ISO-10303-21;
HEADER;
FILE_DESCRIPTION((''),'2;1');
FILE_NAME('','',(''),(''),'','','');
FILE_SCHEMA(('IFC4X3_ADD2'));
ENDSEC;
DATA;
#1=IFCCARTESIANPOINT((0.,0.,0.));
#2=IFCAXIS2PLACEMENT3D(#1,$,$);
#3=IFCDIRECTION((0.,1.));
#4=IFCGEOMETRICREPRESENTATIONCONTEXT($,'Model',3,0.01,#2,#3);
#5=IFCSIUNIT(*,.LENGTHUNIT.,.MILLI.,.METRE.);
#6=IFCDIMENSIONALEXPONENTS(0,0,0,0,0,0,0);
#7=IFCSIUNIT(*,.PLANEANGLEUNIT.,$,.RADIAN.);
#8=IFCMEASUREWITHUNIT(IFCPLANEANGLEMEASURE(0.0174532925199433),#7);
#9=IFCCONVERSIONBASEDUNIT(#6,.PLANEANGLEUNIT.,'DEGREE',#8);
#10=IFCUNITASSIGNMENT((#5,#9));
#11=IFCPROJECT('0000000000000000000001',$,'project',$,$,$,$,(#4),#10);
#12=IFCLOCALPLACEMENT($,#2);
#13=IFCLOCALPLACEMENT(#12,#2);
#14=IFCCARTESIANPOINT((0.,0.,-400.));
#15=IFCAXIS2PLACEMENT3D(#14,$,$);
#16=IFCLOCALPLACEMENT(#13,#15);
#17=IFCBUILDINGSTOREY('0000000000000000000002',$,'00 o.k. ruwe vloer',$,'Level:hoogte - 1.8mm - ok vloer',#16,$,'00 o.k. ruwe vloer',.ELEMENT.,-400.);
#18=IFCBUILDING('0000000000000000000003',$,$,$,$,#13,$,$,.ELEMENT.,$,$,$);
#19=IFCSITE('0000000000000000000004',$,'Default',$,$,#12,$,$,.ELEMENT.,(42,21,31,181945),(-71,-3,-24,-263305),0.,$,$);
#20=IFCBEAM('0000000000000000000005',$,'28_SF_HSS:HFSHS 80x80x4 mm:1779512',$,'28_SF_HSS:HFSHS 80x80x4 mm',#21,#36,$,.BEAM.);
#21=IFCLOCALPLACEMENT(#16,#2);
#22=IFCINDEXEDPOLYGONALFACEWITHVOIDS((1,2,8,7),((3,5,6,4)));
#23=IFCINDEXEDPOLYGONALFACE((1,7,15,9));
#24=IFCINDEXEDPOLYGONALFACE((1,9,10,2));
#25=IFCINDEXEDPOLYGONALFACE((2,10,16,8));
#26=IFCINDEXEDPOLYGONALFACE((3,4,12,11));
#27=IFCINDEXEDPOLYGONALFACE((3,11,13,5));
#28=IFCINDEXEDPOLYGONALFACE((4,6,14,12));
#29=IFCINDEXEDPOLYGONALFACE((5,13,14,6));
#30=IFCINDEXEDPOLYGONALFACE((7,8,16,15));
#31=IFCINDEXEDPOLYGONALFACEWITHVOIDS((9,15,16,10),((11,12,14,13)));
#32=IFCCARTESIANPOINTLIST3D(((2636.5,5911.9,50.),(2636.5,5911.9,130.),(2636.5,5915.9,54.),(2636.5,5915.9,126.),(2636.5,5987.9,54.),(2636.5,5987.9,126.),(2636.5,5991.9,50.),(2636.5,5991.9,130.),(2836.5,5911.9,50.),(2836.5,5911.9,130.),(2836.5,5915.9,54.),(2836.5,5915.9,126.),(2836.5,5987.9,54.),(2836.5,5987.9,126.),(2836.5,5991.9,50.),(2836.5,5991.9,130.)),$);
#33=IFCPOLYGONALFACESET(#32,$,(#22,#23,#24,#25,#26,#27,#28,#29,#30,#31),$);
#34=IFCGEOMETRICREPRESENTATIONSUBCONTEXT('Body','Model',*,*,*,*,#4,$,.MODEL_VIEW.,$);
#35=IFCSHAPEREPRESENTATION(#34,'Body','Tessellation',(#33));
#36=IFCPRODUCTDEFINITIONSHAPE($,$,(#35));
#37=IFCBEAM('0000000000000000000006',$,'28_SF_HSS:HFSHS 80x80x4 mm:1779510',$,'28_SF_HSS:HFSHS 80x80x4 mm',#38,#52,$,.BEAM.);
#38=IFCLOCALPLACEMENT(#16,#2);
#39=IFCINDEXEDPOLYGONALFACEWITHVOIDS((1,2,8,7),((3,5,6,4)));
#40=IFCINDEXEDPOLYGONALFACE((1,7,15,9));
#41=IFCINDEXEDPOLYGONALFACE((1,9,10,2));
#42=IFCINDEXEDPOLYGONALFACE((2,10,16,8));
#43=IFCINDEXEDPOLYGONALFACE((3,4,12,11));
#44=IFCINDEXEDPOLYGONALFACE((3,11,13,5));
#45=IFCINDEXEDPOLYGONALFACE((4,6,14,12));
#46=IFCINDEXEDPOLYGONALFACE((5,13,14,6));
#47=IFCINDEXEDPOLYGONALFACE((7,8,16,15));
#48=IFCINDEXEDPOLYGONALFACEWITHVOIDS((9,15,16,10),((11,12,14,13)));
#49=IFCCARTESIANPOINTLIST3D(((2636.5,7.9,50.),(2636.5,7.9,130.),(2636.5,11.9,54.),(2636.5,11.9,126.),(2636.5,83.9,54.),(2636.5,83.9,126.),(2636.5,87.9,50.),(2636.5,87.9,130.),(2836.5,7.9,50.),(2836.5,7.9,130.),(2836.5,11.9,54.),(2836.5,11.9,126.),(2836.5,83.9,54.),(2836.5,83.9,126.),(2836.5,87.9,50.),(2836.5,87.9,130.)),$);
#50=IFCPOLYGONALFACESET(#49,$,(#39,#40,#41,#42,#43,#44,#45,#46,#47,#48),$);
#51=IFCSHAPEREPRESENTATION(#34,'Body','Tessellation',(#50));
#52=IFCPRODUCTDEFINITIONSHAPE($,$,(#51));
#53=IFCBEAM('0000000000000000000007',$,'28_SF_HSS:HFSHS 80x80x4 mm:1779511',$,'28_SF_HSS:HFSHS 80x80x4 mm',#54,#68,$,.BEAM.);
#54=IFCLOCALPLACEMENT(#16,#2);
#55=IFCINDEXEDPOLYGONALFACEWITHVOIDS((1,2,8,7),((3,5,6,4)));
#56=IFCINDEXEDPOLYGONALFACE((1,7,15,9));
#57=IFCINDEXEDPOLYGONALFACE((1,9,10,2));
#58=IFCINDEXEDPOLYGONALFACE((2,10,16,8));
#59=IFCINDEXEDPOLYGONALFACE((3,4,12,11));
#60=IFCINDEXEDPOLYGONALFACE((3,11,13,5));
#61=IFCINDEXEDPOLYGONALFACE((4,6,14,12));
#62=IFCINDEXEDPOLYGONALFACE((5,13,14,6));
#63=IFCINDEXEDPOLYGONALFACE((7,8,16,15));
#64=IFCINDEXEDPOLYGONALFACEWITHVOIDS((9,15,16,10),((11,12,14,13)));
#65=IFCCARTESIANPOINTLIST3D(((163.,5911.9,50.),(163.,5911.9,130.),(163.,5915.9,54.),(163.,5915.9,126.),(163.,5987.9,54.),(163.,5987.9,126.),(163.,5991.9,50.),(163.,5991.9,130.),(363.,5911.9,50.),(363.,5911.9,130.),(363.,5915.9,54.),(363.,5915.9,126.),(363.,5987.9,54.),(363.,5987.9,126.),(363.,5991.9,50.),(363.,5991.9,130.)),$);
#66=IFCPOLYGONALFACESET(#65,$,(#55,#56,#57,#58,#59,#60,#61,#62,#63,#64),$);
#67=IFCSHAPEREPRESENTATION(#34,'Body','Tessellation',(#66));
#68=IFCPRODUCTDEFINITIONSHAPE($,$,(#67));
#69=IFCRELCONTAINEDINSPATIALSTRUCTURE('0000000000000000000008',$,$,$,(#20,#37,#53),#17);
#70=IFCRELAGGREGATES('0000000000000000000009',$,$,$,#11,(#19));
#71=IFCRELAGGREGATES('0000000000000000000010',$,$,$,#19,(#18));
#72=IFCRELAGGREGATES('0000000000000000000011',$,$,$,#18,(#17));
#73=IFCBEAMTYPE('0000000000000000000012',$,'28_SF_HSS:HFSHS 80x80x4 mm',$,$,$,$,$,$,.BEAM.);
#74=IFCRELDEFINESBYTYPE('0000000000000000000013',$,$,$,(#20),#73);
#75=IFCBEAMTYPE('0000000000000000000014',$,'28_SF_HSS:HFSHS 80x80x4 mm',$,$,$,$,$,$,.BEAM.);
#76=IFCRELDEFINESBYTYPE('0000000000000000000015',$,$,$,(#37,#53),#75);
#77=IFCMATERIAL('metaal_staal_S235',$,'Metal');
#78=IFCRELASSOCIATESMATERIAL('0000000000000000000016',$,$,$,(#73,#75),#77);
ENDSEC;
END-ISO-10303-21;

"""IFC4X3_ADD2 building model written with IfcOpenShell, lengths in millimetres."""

from ifc_helpers import new_model, entity, si_unit, converted_unit, direction, frame, origin, place, context, subcontext, project, spatial, polyline, outline, extrude, source, transform, mapped, material, material_profile, profile_set, type_object, type_shapes, element, save


model = new_model("IFC4X3_ADD2")

# Units and contexts
model_context = context("Model", 3, precision=0.01, world=origin(), true_north=direction((0.0, 1.0)))
body_context = subcontext(model_context, "Body", "Model", "MODEL_VIEW")
ifc_project = project(units=[si_unit("LENGTHUNIT", "METRE", prefix="MILLI"), converted_unit("PLANEANGLEUNIT", "DEGREE", entity("IfcPlaneAngleMeasure", 0.0174532925199433), si_unit("PLANEANGLEUNIT", "RADIAN"), dimensions=[0, 0, 0, 0, 0, 0, 0])], contexts=[model_context])

# Site, building, storey
site_placement = place(None, origin())
site = spatial("IfcSite", under=ifc_project, at=site_placement, Name="Default", CompositionType="ELEMENT", RefLatitude=(42, 21, 31, 181945), RefLongitude=(-71, -3, -24, -263305), RefElevation=0.0)
building_placement = place(site_placement, origin())
building = spatial("IfcBuilding", under=site, at=building_placement, CompositionType="ELEMENT")
storey_placement = place(building_placement, frame((0.0, 0.0, -400.0)))
storey = spatial("IfcBuildingStorey", under=building, at=storey_placement, Name="00 o.k. ruwe vloer", ObjectType="Level:hoogte - 1.8mm - ok vloer", LongName="00 o.k. ruwe vloer", CompositionType="ELEMENT", Elevation=-400.0)

# Shared definitions
ifc_material = material(Name="metaal_staal_S235", Category="Metal")

# Beams
ifc_material_profile_1 = material_profile(ifc_material, outline(polyline([(-40.0, -40.0), (40.0, -40.0), (40.0, 40.0), (-40.0, 40.0), (-40.0, -40.0)]), holes=[polyline([(-36.0, -36.0), (-36.0, 36.0), (36.0, 36.0), (36.0, -36.0), (-36.0, -36.0)])]), Name="HFSHS 80x80x4 mm")
ifc_profile_set_1 = profile_set([ifc_material_profile_1], Name="HFSHS 80x80x4 mm")
beam_type_1 = type_object("IfcBeamType", Name="28_SF_HSS:HFSHS 80x80x4 mm", PredefinedType="BEAM", material=ifc_profile_set_1)
shared_shape_1 = source(origin(), body_context, "Body", "SweptSolid", [
    extrude(outline(polyline([(-40.0, -40.0), (40.0, -40.0), (40.0, 40.0), (-40.0, 40.0), (-40.0, -40.0)]), holes=[polyline([(-36.0, -36.0), (-36.0, 36.0), (36.0, 36.0), (36.0, -36.0), (-36.0, -36.0)])]), frame((-100.0, 0.0, 0.0), z_axis=(1.0, 0.0, 0.0), x_axis=(0.0, -1.0, 0.0)), (0.0, 0.0, 1.0), 200.0),
])
type_shapes(beam_type_1, [shared_shape_1])
beam_1_placement = place(storey_placement, frame((2736.5, 5951.9, 90.0)))
element("IfcBeam", 1, at=beam_1_placement, inside=storey, type_object=beam_type_1, Name="28_SF_HSS:HFSHS 80x80x4 mm:1779512", ObjectType="28_SF_HSS:HFSHS 80x80x4 mm", PredefinedType="BEAM", context=body_context, shape_type="MappedRepresentation", body=[
    mapped(shared_shape_1, transform((0.0, 0.0, 0.0), scale=1.0)),
])
beam_type_2 = type_object("IfcBeamType", Name="28_SF_HSS:HFSHS 80x80x4 mm", PredefinedType="BEAM", material=ifc_profile_set_1)
shared_shape_2 = source(origin(), body_context, "Body", "SweptSolid", [
    extrude(outline(polyline([(-40.0, -40.0), (40.0, -40.0), (40.0, 40.0), (-40.0, 40.0), (-40.0, -40.0)]), holes=[polyline([(-36.0, -36.0), (-36.0, 36.0), (36.0, 36.0), (36.0, -36.0), (-36.0, -36.0)])]), frame((-100.0, 0.0, 0.0), z_axis=(1.0, 0.0, 0.0), x_axis=(0.0, 0.0, -1.0)), (0.0, 0.0, 1.0), 200.0),
])
type_shapes(beam_type_2, [shared_shape_2])
beam_2_placement = place(storey_placement, frame((2736.5, 47.9, 90.0)))
element("IfcBeam", 2, at=beam_2_placement, inside=storey, type_object=beam_type_2, Name="28_SF_HSS:HFSHS 80x80x4 mm:1779510", ObjectType="28_SF_HSS:HFSHS 80x80x4 mm", PredefinedType="BEAM", context=body_context, shape_type="MappedRepresentation", body=[
    mapped(shared_shape_2, transform((0.0, 0.0, 0.0), scale=1.0)),
])
beam_3_placement = place(storey_placement, frame((263.0, 5951.9, 90.0), z_axis=(0.0, 0.0, 1.0), x_axis=(-1.0, 0.0, 0.0)))
element("IfcBeam", 3, at=beam_3_placement, inside=storey, type_object=beam_type_2, Name="28_SF_HSS:HFSHS 80x80x4 mm:1779511", ObjectType="28_SF_HSS:HFSHS 80x80x4 mm", PredefinedType="BEAM", context=body_context, shape_type="MappedRepresentation", body=[
    mapped(shared_shape_2, transform((0.0, 0.0, 0.0), scale=1.0)),
])

save(model, "model.ifc")
